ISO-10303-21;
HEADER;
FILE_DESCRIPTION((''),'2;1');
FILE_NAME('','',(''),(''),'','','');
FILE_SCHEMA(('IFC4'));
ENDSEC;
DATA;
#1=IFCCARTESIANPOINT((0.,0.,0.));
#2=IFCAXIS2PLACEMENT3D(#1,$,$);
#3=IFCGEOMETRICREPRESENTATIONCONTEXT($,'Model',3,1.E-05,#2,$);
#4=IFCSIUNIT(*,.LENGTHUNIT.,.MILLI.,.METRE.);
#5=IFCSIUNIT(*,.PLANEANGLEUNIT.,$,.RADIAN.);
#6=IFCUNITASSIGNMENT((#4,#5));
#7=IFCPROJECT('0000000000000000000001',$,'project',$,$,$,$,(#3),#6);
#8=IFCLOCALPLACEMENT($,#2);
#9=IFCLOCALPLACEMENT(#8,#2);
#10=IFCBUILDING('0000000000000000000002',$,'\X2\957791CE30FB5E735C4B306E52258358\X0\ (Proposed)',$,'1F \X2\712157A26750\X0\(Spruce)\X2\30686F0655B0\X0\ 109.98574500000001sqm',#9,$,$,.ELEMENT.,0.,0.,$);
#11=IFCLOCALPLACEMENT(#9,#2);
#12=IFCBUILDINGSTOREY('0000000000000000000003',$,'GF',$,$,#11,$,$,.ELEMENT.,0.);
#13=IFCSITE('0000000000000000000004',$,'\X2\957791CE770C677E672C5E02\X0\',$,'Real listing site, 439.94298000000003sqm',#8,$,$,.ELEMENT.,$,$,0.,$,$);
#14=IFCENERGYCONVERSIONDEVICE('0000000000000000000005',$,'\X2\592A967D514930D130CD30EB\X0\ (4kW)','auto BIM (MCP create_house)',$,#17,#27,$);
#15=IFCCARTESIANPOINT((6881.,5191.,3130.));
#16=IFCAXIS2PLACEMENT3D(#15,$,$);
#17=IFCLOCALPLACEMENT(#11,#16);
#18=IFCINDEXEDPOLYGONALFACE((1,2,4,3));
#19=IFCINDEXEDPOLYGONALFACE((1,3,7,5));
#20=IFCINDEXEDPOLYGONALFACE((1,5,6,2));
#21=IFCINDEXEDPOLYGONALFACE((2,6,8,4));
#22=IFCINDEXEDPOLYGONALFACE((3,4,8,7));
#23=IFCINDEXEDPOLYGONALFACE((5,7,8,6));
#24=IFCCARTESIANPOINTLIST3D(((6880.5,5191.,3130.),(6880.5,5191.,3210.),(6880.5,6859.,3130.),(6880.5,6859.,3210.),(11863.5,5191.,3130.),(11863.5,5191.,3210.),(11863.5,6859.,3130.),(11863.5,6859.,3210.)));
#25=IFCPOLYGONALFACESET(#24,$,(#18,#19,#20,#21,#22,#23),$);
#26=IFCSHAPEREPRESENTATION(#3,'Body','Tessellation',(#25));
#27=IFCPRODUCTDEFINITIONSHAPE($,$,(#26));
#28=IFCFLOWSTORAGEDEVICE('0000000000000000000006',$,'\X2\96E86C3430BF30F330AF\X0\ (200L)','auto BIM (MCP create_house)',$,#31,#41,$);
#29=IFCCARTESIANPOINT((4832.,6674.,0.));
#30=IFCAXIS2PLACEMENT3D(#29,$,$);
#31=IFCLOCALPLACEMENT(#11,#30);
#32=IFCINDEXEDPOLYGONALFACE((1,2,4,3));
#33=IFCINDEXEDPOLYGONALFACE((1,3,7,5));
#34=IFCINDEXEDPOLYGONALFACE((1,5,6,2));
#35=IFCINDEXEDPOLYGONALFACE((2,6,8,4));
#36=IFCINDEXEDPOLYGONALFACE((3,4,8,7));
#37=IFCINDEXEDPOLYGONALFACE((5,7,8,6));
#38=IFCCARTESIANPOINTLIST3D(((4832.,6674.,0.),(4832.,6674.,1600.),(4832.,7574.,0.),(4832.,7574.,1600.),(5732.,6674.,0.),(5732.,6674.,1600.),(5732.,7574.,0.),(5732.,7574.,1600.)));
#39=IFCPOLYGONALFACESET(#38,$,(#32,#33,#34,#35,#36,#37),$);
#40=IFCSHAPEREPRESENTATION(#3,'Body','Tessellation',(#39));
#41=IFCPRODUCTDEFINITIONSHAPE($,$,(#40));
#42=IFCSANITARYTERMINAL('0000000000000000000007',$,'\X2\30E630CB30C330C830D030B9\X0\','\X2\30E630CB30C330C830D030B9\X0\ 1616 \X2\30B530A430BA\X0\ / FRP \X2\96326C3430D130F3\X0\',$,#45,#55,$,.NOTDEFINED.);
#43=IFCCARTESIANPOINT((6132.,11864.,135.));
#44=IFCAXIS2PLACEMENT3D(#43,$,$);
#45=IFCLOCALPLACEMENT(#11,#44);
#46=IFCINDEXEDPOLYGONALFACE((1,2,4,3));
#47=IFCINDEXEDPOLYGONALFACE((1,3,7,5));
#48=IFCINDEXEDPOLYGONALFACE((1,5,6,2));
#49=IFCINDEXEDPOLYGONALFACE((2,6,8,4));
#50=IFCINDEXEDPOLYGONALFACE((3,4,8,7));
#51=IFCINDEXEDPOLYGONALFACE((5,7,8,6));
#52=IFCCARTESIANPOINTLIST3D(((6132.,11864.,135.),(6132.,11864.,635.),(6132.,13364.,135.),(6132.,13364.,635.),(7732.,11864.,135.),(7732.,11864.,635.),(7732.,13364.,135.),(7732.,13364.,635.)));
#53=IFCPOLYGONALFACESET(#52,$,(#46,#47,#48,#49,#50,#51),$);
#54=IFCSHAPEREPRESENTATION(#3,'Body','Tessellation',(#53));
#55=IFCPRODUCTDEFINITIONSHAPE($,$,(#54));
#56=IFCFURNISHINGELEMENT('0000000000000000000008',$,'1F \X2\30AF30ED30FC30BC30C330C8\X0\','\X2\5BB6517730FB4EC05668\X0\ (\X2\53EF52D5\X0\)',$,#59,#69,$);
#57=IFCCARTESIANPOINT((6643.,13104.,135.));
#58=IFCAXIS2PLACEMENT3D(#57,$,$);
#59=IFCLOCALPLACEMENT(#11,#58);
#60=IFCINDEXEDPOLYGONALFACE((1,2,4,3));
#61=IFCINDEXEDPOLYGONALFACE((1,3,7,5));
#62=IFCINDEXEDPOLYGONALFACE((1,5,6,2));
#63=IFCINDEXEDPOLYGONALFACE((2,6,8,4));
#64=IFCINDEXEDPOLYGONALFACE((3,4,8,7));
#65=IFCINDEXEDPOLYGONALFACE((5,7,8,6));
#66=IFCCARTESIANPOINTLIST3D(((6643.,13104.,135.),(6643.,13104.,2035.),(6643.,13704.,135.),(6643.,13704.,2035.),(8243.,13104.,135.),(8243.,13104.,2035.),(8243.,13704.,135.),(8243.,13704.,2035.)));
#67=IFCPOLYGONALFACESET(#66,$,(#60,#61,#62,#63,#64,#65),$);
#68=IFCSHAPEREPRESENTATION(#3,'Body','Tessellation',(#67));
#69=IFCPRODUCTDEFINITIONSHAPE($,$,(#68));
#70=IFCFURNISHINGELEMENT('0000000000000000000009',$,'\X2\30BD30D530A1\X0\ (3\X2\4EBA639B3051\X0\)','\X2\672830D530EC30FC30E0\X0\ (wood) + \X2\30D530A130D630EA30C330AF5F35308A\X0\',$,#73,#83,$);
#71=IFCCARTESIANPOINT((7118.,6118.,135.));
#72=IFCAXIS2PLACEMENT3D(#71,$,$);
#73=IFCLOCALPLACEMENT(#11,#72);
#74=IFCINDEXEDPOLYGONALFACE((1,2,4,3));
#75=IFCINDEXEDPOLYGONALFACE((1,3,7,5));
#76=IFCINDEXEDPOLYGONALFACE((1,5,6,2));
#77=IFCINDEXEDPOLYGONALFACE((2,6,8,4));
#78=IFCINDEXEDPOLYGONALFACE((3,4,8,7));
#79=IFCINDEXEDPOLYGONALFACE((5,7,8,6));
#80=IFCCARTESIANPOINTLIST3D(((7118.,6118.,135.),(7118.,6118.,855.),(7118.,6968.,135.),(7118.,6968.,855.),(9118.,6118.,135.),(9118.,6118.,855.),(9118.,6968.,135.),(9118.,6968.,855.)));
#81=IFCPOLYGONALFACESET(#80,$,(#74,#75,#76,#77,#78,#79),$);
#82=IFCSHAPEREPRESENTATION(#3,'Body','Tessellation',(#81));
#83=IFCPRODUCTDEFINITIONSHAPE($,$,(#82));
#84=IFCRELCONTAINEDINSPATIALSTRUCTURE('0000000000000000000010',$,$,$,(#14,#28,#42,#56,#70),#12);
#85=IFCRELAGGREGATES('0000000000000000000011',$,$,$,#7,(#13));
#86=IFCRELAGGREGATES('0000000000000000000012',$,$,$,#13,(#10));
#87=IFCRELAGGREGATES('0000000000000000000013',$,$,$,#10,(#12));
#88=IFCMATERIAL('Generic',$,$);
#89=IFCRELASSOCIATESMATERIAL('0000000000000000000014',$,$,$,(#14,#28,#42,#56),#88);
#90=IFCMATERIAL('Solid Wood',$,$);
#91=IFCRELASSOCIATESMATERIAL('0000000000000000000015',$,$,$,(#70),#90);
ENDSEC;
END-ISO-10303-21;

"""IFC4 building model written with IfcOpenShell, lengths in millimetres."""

from ifc_helpers import new_model, si_unit, frame, frame_2d, origin, place, context, project, spatial, rectangle, extrude, material, element, save


model = new_model("IFC4")

# Units and contexts
model_context = context("Model", 3, precision=1e-05, world=origin())
ifc_project = project(units=[si_unit("LENGTHUNIT", "METRE", prefix="MILLI"), si_unit("PLANEANGLEUNIT", "RADIAN")], contexts=[model_context])

# Site, building, storey
site_placement = place(None, origin())
site = spatial("IfcSite", under=ifc_project, at=site_placement, Name="長野県松本市", ObjectType="Real listing site, 439.94298000000003sqm", CompositionType="ELEMENT", RefElevation=0.0)
building_placement = place(site_placement, origin())
building = spatial("IfcBuilding", under=site, at=building_placement, Name="長野・平屋の別荘 (Proposed)", ObjectType="1F 無垢材(Spruce)と漆喰 109.98574500000001sqm", CompositionType="ELEMENT", ElevationOfRefHeight=0.0, ElevationOfTerrain=0.0)
storey_placement = place(building_placement, origin())
storey = spatial("IfcBuildingStorey", under=building, at=storey_placement, Name="GF", CompositionType="ELEMENT", Elevation=0.0)

# Shared definitions
ifc_material_1 = material(Name="Solid Wood")

# Shared definitions
ifc_material_2 = material(Name="Generic")

# Energy conversion device
energy_conversion_device_placement = place(storey_placement, frame((6881.0, 5191.0, 3130.0)))
element("IfcEnergyConversionDevice", 1, at=energy_conversion_device_placement, inside=storey, material=ifc_material_2, Name="太陽光パネル (4kW)", Description="auto BIM (MCP create_house)", context=model_context, shape_type="SweptSolid", body=[
    extrude(rectangle(XDim=4983.0, YDim=1668.0, at=frame_2d((2491.0, 834.0))), frame((6881.0, 5191.0, 3130.0)), (0.0, 0.0, 1.0), 80.0),
])

# Flow storage device
flow_storage_device_placement = place(storey_placement, frame((4832.0, 6674.0, 0.0)))
element("IfcFlowStorageDevice", 2, at=flow_storage_device_placement, inside=storey, material=ifc_material_2, Name="雨水タンク (200L)", Description="auto BIM (MCP create_house)", context=model_context, shape_type="SweptSolid", body=[
    extrude(rectangle(XDim=900.0, YDim=900.0, at=frame_2d((450.0, 450.0))), frame((4832.0, 6674.0, 0.0)), (0.0, 0.0, 1.0), 1600.0),
])

# Sanitary terminal
sanitary_terminal_placement = place(storey_placement, frame((6132.0, 11864.0, 135.0)))
element("IfcSanitaryTerminal", 3, at=sanitary_terminal_placement, inside=storey, material=ifc_material_2, Name="ユニットバス", Description="ユニットバス 1616 サイズ / FRP 防水パン", PredefinedType="NOTDEFINED", context=model_context, shape_type="SweptSolid", body=[
    extrude(rectangle(XDim=1600.0, YDim=1500.0, at=frame_2d((800.0, 750.0))), frame((6132.0, 11864.0, 135.0)), (0.0, 0.0, 1.0), 500.0),
])

# Furnishing elements
furnishing_1_placement = place(storey_placement, frame((6643.0, 13104.0, 135.0)))
element("IfcFurnishingElement", 4, at=furnishing_1_placement, inside=storey, material=ifc_material_2, Name="1F クローゼット", Description="家具・什器 (可動)", context=model_context, shape_type="SweptSolid", body=[
    extrude(rectangle(XDim=1600.0, YDim=600.0, at=frame_2d((800.0, 300.0))), frame((6643.0, 13104.0, 135.0)), (0.0, 0.0, 1.0), 1900.0),
])
furnishing_2_placement = place(storey_placement, frame((7118.0, 6118.0, 135.0)))
element("IfcFurnishingElement", 5, at=furnishing_2_placement, inside=storey, material=ifc_material_1, Name="ソファ (3人掛け)", Description="木フレーム (wood) + ファブリック張り", context=model_context, shape_type="SweptSolid", body=[
    extrude(rectangle(XDim=2000.0, YDim=850.0, at=frame_2d((1000.0, 425.0))), frame((7118.0, 6118.0, 135.0)), (0.0, 0.0, 1.0), 720.0),
])

save(model, "model.ifc")
